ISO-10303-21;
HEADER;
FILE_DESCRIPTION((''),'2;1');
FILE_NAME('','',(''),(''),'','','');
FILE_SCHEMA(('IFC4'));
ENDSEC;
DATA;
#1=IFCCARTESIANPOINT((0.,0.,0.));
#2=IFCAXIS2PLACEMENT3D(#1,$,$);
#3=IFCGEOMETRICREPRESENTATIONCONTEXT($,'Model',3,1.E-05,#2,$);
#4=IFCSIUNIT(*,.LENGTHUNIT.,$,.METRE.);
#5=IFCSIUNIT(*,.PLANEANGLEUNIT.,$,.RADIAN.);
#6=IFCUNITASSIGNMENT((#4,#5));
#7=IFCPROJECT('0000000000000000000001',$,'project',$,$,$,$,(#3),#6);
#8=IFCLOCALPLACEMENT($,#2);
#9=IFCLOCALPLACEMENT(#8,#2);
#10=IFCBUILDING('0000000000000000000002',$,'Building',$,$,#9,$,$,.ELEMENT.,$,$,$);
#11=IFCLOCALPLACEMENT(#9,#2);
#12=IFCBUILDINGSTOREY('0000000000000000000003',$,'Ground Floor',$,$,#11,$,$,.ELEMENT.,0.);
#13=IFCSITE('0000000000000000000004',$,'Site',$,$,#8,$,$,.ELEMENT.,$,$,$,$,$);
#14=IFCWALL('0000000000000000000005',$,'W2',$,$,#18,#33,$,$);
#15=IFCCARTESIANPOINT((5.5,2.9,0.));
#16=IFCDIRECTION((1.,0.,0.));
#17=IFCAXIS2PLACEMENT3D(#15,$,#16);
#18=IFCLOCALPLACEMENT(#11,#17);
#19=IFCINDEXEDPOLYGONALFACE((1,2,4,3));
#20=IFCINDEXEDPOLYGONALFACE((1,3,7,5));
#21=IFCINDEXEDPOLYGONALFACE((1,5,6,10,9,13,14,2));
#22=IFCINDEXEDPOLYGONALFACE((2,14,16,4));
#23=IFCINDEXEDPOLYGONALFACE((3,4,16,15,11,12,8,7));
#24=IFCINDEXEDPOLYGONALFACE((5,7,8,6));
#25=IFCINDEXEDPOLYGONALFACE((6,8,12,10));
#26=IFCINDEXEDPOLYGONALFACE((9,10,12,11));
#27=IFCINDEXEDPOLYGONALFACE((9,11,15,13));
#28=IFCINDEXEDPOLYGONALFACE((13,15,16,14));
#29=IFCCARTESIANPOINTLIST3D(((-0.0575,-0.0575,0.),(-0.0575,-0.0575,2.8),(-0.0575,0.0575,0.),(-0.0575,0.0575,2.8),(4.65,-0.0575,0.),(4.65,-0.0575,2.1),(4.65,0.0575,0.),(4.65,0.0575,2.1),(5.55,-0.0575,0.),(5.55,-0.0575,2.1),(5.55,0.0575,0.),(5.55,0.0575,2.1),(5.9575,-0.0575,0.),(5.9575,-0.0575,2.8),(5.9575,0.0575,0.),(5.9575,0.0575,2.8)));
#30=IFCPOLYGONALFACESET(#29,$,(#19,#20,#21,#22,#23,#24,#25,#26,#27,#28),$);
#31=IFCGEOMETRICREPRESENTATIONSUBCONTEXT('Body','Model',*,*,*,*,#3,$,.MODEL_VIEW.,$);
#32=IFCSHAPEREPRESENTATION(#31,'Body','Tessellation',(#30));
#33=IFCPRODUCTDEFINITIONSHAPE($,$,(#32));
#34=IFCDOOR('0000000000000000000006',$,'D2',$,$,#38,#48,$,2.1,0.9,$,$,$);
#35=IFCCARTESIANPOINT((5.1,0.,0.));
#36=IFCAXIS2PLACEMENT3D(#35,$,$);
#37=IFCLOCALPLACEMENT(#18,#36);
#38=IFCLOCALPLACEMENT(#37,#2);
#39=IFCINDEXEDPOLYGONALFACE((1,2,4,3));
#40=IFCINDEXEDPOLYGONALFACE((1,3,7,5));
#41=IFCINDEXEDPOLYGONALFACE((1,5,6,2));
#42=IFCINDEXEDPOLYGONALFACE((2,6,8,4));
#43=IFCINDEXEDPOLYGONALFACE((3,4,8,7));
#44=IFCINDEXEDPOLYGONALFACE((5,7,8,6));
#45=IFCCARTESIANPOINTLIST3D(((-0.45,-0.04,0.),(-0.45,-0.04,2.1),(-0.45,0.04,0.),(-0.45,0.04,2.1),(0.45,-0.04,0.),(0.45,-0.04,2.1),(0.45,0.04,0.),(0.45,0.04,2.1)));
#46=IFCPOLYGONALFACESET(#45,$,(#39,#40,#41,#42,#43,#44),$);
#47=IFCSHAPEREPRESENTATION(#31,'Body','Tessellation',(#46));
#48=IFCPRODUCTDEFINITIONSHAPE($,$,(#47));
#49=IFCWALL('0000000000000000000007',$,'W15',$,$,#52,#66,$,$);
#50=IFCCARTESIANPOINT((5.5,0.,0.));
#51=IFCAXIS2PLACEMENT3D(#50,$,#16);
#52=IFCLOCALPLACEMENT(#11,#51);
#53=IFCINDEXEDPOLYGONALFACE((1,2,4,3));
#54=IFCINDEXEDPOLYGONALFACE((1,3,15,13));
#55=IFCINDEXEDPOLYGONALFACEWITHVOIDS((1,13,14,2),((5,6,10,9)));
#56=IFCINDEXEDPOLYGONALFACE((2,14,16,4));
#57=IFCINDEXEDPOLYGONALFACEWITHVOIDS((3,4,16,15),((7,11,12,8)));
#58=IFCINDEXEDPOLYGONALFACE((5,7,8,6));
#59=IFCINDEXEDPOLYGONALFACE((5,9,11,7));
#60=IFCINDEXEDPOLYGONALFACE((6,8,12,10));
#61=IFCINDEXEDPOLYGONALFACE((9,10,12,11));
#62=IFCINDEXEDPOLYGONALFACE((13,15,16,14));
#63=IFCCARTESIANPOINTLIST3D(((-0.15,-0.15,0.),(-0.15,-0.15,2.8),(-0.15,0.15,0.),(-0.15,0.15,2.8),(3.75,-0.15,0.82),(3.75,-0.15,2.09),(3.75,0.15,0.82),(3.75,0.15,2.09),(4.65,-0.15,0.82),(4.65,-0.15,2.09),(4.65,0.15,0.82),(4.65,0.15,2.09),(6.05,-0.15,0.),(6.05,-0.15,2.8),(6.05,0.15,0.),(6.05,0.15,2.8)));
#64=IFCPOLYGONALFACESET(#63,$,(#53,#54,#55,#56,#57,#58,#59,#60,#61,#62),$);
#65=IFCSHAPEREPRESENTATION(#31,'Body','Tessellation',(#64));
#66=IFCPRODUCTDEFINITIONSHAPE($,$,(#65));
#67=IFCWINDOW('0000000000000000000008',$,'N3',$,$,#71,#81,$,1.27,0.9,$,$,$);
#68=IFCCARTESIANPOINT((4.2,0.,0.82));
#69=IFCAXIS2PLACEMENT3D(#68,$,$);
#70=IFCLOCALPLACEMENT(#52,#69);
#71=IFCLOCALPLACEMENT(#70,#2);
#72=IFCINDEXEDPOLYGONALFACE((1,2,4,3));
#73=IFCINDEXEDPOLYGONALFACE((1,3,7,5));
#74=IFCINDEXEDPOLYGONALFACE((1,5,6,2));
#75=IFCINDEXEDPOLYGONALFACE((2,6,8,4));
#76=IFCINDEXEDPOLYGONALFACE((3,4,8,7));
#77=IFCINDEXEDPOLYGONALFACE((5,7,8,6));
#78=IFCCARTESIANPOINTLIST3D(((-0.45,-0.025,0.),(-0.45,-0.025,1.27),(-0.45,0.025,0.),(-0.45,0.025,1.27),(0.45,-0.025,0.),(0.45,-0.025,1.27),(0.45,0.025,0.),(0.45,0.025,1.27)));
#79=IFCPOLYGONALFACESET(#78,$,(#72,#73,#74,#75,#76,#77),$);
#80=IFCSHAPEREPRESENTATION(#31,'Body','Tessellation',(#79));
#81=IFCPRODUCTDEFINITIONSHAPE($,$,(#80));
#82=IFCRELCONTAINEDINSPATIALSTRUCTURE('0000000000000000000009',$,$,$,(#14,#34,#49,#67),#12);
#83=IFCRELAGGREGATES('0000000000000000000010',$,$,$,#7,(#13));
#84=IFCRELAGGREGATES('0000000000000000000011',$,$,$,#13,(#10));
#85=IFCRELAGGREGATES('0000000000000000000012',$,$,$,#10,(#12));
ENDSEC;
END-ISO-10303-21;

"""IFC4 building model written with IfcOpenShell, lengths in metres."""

from ifc_helpers import new_model, si_unit, frame, frame_2d, origin, origin_2d, place, context, subcontext, project, spatial, rectangle, extrude, element, fill, save


model = new_model("IFC4")

# Units and contexts
model_context = context("Model", 3, precision=1e-05, world=origin())
body_context = subcontext(model_context, "Body", "Model", "MODEL_VIEW")
ifc_project = project(units=[si_unit("LENGTHUNIT", "METRE"), si_unit("PLANEANGLEUNIT", "RADIAN")], contexts=[model_context])

# Site, building, storey
site_placement = place(None, origin())
site = spatial("IfcSite", under=ifc_project, at=site_placement, Name="Site", CompositionType="ELEMENT")
building_placement = place(site_placement, origin())
building = spatial("IfcBuilding", under=site, at=building_placement, Name="Building", CompositionType="ELEMENT")
storey_placement = place(building_placement, origin())
storey = spatial("IfcBuildingStorey", under=building, at=storey_placement, Name="Ground Floor", CompositionType="ELEMENT", Elevation=0.0)

# Wall, opening, door
wall_1_placement = place(storey_placement, frame((5.5, 2.9, 0.0), x_axis=(1.0, 0.0, 0.0)))
wall_1 = element("IfcWall", 1, at=wall_1_placement, inside=storey, Name="W2", context=body_context, shape_type="SweptSolid", body=[
    extrude(rectangle(XDim=6.015, YDim=0.115, at=frame_2d((2.95, 0.0))), origin(), (0.0, 0.0, 1.0), 2.8),
])
opening_1_placement = place(wall_1_placement, frame((5.1, 0.0, 0.0)))
opening_1 = element("IfcOpeningElement", 2, at=opening_1_placement, cuts=wall_1, context=body_context, shape_type="SweptSolid", body=[
    extrude(rectangle(XDim=0.9, YDim=0.215, at=origin_2d()), origin(), (0.0, 0.0, 1.0), 2.1),
])
door_1_placement = place(opening_1_placement, origin())
door_1 = element("IfcDoor", 3, at=door_1_placement, inside=storey, Name="D2", OverallHeight=2.1, OverallWidth=0.9, context=body_context, shape_type="SweptSolid", body=[
    extrude(rectangle(XDim=0.9, YDim=0.08, at=origin_2d()), origin(), (0.0, 0.0, 1.0), 2.1),
])
fill(opening_1, door_1)

# Wall, opening, window
wall_2_placement = place(storey_placement, frame((5.5, 0.0, 0.0), x_axis=(1.0, 0.0, 0.0)))
wall_2 = element("IfcWall", 4, at=wall_2_placement, inside=storey, Name="W15", context=body_context, shape_type="SweptSolid", body=[
    extrude(rectangle(XDim=6.2, YDim=0.3, at=frame_2d((2.95, 0.0))), origin(), (0.0, 0.0, 1.0), 2.8),
])
opening_2_placement = place(wall_2_placement, frame((4.2, 0.0, 0.82)))
opening_2 = element("IfcOpeningElement", 5, at=opening_2_placement, cuts=wall_2, context=body_context, shape_type="SweptSolid", body=[
    extrude(rectangle(XDim=0.9, YDim=0.4, at=origin_2d()), origin(), (0.0, 0.0, 1.0), 1.27),
])
window_1_placement = place(opening_2_placement, origin())
window_1 = element("IfcWindow", 6, at=window_1_placement, inside=storey, Name="N3", OverallHeight=1.27, OverallWidth=0.9, context=body_context, shape_type="SweptSolid", body=[
    extrude(rectangle(XDim=0.9, YDim=0.05, at=origin_2d()), origin(), (0.0, 0.0, 1.0), 1.27),
])
fill(opening_2, window_1)

save(model, "model.ifc")
